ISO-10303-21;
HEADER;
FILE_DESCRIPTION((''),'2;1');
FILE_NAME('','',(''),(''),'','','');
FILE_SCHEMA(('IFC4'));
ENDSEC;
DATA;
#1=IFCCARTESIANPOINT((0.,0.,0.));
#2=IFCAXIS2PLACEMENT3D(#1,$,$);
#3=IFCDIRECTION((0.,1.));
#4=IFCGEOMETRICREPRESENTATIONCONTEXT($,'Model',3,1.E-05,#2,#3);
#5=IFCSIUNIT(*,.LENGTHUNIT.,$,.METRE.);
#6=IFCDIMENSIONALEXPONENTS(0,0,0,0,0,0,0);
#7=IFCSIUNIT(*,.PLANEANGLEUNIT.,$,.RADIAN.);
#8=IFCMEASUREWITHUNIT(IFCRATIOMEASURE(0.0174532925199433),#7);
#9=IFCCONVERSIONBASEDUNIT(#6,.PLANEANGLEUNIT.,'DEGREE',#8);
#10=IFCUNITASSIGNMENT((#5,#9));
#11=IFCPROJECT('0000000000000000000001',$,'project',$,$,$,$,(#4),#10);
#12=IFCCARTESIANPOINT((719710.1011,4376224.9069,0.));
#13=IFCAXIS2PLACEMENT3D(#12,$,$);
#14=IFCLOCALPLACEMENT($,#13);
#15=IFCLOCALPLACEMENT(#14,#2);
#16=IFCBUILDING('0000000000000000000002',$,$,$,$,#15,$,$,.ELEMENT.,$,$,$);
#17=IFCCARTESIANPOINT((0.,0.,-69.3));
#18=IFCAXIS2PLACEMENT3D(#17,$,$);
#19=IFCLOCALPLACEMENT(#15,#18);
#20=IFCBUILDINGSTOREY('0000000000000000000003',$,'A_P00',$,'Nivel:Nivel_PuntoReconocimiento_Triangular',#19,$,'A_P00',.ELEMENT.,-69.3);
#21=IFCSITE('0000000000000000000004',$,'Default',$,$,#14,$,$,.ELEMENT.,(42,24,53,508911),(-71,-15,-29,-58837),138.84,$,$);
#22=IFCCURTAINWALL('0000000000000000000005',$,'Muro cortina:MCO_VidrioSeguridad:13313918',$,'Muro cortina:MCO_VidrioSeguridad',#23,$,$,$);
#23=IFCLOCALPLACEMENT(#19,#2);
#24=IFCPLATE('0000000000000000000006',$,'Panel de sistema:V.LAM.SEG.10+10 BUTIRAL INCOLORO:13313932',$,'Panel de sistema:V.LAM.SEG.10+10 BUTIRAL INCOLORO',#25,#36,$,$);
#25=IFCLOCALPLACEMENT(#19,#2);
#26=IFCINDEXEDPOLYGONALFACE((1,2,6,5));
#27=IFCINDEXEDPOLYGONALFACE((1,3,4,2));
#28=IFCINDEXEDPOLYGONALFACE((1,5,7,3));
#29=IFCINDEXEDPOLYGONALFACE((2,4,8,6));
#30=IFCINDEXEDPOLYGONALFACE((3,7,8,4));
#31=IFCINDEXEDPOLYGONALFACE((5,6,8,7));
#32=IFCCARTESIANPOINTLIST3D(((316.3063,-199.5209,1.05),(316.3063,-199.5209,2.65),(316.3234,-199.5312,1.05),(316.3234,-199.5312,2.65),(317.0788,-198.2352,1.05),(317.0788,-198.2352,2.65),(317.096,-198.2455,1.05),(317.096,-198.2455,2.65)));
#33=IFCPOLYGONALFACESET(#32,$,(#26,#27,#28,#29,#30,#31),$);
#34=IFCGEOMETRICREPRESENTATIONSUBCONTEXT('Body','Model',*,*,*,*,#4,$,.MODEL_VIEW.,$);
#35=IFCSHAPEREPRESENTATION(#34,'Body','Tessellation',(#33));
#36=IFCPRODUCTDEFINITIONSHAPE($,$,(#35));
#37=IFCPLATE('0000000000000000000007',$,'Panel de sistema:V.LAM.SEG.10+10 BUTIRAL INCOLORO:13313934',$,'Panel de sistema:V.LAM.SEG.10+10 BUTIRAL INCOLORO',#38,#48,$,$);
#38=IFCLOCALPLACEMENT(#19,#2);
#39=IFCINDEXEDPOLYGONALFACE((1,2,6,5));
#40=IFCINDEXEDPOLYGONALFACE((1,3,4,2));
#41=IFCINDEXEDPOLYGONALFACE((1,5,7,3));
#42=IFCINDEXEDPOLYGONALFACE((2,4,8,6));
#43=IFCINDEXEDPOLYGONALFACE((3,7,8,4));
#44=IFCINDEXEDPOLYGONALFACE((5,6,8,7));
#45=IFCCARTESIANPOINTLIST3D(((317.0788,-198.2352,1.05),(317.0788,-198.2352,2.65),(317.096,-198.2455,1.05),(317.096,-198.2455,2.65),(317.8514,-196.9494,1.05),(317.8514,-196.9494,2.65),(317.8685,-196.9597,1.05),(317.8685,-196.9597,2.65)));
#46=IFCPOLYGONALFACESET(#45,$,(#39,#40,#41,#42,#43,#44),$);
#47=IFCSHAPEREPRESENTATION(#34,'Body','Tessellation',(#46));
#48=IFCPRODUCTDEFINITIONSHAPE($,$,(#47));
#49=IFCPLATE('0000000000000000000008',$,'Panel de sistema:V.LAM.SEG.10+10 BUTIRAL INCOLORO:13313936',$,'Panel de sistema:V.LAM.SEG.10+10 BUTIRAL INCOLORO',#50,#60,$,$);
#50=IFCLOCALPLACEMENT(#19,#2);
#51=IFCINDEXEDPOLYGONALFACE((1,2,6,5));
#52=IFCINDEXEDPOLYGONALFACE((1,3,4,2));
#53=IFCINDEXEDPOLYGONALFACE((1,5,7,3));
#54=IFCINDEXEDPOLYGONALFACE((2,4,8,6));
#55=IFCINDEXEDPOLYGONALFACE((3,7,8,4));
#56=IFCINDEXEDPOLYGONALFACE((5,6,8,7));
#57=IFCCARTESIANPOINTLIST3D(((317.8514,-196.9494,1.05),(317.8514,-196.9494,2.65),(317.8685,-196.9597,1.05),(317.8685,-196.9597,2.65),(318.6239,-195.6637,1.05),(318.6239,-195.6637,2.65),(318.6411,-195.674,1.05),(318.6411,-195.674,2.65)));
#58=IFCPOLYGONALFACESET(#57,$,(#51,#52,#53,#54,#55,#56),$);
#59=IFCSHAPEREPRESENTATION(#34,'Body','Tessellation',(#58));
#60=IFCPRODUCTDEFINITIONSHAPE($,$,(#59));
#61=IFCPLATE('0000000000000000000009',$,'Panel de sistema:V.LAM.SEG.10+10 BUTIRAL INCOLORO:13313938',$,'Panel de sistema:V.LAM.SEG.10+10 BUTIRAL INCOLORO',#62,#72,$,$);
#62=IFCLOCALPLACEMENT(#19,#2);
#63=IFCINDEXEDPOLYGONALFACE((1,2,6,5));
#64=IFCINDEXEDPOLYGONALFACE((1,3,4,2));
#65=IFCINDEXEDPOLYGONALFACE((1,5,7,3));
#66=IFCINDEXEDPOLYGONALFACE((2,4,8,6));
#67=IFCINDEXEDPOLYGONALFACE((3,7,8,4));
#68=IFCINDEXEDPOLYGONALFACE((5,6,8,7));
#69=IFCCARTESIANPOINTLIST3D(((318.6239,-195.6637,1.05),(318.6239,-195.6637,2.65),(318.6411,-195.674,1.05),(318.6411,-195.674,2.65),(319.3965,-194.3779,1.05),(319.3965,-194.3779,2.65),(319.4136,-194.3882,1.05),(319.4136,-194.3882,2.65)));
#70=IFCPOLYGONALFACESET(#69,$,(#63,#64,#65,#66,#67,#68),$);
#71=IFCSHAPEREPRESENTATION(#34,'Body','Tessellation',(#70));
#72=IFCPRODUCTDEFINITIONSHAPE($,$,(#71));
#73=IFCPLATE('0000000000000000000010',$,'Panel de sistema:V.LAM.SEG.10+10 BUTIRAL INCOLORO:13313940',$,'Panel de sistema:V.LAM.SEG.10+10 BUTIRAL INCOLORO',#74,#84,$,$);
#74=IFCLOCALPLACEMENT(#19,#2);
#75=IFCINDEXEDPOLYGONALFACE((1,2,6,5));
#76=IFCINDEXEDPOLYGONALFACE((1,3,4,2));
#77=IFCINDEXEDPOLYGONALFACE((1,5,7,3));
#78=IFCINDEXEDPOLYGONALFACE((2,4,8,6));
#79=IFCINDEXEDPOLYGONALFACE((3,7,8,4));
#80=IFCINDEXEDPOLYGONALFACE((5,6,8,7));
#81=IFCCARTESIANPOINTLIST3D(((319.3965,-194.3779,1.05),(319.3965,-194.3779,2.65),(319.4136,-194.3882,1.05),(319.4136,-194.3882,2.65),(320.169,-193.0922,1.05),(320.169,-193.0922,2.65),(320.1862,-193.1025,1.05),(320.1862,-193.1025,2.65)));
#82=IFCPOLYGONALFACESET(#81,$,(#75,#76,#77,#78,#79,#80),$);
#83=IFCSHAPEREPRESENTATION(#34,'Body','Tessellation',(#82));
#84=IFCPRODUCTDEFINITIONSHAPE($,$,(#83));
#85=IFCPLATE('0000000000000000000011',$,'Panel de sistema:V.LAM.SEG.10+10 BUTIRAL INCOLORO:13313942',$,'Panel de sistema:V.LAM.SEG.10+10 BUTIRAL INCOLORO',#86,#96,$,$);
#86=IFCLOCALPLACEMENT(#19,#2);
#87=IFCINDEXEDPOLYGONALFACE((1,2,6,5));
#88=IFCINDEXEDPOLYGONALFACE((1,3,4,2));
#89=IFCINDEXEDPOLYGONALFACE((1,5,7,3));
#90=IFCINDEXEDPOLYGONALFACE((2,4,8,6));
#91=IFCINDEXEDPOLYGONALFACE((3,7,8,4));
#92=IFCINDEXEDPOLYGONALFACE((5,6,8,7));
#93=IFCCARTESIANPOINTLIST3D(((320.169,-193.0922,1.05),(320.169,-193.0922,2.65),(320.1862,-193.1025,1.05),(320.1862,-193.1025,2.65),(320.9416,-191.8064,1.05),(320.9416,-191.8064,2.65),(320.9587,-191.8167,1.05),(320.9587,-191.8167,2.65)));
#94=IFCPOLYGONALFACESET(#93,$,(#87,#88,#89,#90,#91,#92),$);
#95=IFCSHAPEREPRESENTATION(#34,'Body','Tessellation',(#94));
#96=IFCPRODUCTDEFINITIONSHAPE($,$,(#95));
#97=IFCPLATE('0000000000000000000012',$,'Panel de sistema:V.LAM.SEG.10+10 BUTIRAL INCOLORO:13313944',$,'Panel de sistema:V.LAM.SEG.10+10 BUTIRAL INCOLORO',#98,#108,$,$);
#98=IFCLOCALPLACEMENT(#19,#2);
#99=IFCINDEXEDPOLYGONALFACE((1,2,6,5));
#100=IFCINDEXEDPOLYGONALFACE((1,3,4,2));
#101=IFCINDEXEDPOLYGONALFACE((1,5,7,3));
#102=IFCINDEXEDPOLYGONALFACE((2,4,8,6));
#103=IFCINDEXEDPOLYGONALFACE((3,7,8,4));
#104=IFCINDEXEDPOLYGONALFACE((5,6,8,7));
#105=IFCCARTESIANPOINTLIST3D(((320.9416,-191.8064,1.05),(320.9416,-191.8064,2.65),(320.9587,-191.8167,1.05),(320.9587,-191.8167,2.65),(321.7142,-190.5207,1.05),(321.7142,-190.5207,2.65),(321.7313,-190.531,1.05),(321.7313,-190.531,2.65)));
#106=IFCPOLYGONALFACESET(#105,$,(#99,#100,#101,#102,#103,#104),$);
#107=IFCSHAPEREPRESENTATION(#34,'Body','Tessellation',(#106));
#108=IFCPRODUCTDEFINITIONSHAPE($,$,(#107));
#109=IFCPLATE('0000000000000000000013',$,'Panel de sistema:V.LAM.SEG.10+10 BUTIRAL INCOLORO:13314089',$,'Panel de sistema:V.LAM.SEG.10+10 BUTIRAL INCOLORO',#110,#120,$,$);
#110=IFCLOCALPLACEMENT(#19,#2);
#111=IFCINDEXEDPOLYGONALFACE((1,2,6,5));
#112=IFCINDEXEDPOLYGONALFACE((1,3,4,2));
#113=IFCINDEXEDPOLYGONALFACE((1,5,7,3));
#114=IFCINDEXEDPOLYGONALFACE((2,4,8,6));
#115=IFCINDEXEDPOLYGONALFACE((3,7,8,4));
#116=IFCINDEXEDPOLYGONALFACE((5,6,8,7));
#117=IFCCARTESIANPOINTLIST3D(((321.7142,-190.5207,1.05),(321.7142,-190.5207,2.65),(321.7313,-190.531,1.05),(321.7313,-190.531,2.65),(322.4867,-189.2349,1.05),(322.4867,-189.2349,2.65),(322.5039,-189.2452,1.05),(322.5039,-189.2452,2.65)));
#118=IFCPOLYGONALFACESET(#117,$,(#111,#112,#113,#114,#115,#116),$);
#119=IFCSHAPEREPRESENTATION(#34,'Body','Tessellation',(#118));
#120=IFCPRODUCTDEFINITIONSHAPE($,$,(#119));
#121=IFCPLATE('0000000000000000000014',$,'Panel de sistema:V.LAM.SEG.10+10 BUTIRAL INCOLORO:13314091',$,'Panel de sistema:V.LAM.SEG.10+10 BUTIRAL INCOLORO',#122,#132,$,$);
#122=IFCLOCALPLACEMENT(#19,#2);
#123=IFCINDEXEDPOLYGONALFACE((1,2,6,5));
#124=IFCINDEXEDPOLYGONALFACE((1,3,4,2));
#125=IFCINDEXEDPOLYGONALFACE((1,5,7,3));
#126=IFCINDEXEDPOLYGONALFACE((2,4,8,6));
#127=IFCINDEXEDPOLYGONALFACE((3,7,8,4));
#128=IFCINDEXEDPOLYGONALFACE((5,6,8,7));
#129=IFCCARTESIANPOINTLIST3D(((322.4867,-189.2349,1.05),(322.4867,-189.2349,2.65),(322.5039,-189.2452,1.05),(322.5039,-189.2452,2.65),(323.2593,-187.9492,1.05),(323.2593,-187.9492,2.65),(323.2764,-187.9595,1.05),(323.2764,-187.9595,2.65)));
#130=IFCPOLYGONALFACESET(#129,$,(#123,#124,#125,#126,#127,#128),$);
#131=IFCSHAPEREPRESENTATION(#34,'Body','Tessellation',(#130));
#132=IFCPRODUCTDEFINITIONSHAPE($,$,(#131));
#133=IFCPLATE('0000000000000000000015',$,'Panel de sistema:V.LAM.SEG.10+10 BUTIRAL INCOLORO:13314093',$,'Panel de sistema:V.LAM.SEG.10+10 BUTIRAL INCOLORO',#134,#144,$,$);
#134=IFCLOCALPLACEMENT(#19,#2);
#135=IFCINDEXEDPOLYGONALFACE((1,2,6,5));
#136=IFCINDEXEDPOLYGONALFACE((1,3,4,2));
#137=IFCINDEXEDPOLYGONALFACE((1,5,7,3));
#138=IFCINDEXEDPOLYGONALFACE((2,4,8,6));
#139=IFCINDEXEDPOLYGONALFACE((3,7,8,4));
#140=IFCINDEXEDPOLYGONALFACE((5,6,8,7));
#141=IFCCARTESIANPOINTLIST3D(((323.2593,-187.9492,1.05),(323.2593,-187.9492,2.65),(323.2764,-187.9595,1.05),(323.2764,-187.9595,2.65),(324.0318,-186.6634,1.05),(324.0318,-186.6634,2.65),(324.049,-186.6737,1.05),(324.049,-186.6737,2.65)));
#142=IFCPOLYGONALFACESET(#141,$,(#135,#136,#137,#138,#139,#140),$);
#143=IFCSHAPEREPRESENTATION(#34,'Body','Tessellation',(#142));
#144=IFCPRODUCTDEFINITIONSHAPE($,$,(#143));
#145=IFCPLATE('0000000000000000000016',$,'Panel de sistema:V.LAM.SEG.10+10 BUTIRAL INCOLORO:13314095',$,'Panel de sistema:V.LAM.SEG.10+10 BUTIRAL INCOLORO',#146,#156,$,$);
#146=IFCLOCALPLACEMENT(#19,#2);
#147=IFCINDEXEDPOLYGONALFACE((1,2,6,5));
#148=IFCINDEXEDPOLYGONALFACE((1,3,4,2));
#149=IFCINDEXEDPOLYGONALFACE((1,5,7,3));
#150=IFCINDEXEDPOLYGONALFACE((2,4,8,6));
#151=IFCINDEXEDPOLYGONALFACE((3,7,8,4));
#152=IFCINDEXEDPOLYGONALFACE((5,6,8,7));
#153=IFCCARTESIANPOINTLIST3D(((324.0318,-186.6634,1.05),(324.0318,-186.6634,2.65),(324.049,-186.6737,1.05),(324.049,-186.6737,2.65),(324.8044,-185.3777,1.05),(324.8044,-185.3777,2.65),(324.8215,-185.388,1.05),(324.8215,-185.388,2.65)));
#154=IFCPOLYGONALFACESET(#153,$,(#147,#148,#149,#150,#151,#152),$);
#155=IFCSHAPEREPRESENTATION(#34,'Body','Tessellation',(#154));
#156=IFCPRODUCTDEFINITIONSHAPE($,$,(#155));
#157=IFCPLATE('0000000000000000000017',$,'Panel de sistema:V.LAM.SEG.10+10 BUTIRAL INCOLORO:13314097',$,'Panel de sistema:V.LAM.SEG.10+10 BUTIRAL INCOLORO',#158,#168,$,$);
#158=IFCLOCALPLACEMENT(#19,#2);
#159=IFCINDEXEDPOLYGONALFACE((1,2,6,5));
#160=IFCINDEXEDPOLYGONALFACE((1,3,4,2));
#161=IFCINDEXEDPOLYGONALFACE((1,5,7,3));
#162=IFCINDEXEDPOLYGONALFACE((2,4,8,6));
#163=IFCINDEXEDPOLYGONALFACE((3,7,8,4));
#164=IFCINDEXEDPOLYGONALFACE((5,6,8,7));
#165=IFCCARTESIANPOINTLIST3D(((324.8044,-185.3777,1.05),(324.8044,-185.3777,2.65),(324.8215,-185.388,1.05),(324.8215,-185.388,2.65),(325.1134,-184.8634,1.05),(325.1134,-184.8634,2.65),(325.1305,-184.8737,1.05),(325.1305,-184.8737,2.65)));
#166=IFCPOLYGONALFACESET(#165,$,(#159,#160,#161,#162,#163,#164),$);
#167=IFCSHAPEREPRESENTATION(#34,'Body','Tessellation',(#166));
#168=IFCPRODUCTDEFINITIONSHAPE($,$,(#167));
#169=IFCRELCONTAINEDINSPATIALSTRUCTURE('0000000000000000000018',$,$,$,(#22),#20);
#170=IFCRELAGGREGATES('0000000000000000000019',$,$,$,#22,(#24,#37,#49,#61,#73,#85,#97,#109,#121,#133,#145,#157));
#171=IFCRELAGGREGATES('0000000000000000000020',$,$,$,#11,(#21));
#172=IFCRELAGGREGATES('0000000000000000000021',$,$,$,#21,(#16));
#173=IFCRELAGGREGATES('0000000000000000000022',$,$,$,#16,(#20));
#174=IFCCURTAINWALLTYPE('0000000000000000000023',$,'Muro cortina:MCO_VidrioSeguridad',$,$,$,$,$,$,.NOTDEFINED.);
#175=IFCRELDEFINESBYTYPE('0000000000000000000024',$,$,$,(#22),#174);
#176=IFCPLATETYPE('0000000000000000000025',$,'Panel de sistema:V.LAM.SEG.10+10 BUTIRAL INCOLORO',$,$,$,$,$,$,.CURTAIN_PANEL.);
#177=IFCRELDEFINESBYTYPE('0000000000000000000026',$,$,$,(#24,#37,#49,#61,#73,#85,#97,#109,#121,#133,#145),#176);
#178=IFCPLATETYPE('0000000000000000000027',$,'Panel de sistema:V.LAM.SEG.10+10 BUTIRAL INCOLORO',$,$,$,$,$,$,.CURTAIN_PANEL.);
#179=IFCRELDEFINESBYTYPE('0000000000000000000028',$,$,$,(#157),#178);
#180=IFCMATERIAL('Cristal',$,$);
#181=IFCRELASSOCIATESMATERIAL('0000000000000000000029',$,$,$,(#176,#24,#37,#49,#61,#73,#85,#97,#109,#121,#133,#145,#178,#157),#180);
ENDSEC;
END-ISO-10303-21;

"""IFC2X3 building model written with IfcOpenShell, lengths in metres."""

from ifc_helpers import new_model, entity, si_unit, converted_unit, direction, frame, frame_2d, origin, origin_2d_with_axis, place, context, subcontext, project, spatial, rectangle, extrude, source, transform, mapped, material, type_object, type_shapes, element, aggregate, save


model = new_model("IFC2X3")

# Units and contexts
model_context = context("Model", 3, precision=1e-05, world=origin(), true_north=direction((0.0, 1.0)))
body_context = subcontext(model_context, "Body", "Model", "MODEL_VIEW")
ifc_project = project(units=[si_unit("LENGTHUNIT", "METRE"), converted_unit("PLANEANGLEUNIT", "DEGREE", entity("IfcRatioMeasure", 0.0174532925199433), si_unit("PLANEANGLEUNIT", "RADIAN"), dimensions=[0, 0, 0, 0, 0, 0, 0])], contexts=[model_context])

# Site, building, storey
site_placement = place(None, frame((719710.1011, 4376224.9069, 0.0)))
site = spatial("IfcSite", under=ifc_project, at=site_placement, Name="Default", CompositionType="ELEMENT", RefLatitude=(42, 24, 53, 508911), RefLongitude=(-71, -15, -29, -58837), RefElevation=138.84)
building_placement = place(site_placement, origin())
building = spatial("IfcBuilding", under=site, at=building_placement, CompositionType="ELEMENT")
storey_placement = place(building_placement, frame((0.0, 0.0, -69.3)))
storey = spatial("IfcBuildingStorey", under=building, at=storey_placement, Name="A_P00", ObjectType="Nivel:Nivel_PuntoReconocimiento_Triangular", LongName="A_P00", CompositionType="ELEMENT", Elevation=-69.3)

# Shared definitions
curtain_wall_type = type_object("IfcCurtainWallType", Name="Muro cortina:MCO_VidrioSeguridad", PredefinedType="NOTDEFINED")
ifc_material_1 = material(Name="Cristal")

# Curtain wall, plates
curtain_wall_1_placement = place(storey_placement, frame((0.0, 0.0, 69.3)))
curtain_wall_1 = element("IfcCurtainWall", 1, at=curtain_wall_1_placement, inside=storey, type_object=curtain_wall_type, Name="Muro cortina:MCO_VidrioSeguridad:13313918", ObjectType="Muro cortina:MCO_VidrioSeguridad")
plate_type_1 = type_object("IfcPlateType", Name="Panel de sistema:V.LAM.SEG.10+10 BUTIRAL INCOLORO", PredefinedType="CURTAIN_PANEL", material=ifc_material_1)
shared_shape_1 = source(origin(), body_context, "Body", "SweptSolid", [
    extrude(rectangle(XDim=0.02, YDim=1.5, at=frame_2d((0.0, 0.0), x_axis=(1.0, 0.0))), frame((0.0, 0.0, 0.0), z_axis=(0.0, 0.0, 1.0), x_axis=(0.0, 1.0, 0.0)), (0.0, 0.0, 1.0), 1.6),
])
type_shapes(plate_type_1, [shared_shape_1])
plate_1_placement = place(curtain_wall_1_placement, frame((316.7011, -198.8832, -68.25), z_axis=(0.0, 0.0, 1.0), x_axis=(0.515038, 0.857167, 0.0)))
plate_1 = element("IfcPlate", 2, at=plate_1_placement, type_object=plate_type_1, material=ifc_material_1, Name="Panel de sistema:V.LAM.SEG.10+10 BUTIRAL INCOLORO:13313932", ObjectType="Panel de sistema:V.LAM.SEG.10+10 BUTIRAL INCOLORO", context=body_context, shape_type="MappedRepresentation", body=[
    mapped(shared_shape_1, transform((0.0, 0.0, 0.0), scale=1.0)),
])
plate_2_placement = place(curtain_wall_1_placement, frame((317.4737, -197.5974, -68.25), z_axis=(0.0, 0.0, 1.0), x_axis=(0.515038, 0.857167, 0.0)))
plate_2 = element("IfcPlate", 3, at=plate_2_placement, type_object=plate_type_1, material=ifc_material_1, Name="Panel de sistema:V.LAM.SEG.10+10 BUTIRAL INCOLORO:13313934", ObjectType="Panel de sistema:V.LAM.SEG.10+10 BUTIRAL INCOLORO", context=body_context, shape_type="MappedRepresentation", body=[
    mapped(shared_shape_1, transform((0.0, 0.0, 0.0), scale=1.0)),
])
plate_3_placement = place(curtain_wall_1_placement, frame((318.2462, -196.3117, -68.25), z_axis=(0.0, 0.0, 1.0), x_axis=(0.515038, 0.857167, 0.0)))
plate_3 = element("IfcPlate", 4, at=plate_3_placement, type_object=plate_type_1, material=ifc_material_1, Name="Panel de sistema:V.LAM.SEG.10+10 BUTIRAL INCOLORO:13313936", ObjectType="Panel de sistema:V.LAM.SEG.10+10 BUTIRAL INCOLORO", context=body_context, shape_type="MappedRepresentation", body=[
    mapped(shared_shape_1, transform((0.0, 0.0, 0.0), scale=1.0)),
])
plate_4_placement = place(curtain_wall_1_placement, frame((319.0188, -195.0259, -68.25), z_axis=(0.0, 0.0, 1.0), x_axis=(0.515038, 0.857167, 0.0)))
plate_4 = element("IfcPlate", 5, at=plate_4_placement, type_object=plate_type_1, material=ifc_material_1, Name="Panel de sistema:V.LAM.SEG.10+10 BUTIRAL INCOLORO:13313938", ObjectType="Panel de sistema:V.LAM.SEG.10+10 BUTIRAL INCOLORO", context=body_context, shape_type="MappedRepresentation", body=[
    mapped(shared_shape_1, transform((0.0, 0.0, 0.0), scale=1.0)),
])
plate_5_placement = place(curtain_wall_1_placement, frame((319.7913, -193.7402, -68.25), z_axis=(0.0, 0.0, 1.0), x_axis=(0.515038, 0.857167, 0.0)))
plate_5 = element("IfcPlate", 6, at=plate_5_placement, type_object=plate_type_1, material=ifc_material_1, Name="Panel de sistema:V.LAM.SEG.10+10 BUTIRAL INCOLORO:13313940", ObjectType="Panel de sistema:V.LAM.SEG.10+10 BUTIRAL INCOLORO", context=body_context, shape_type="MappedRepresentation", body=[
    mapped(shared_shape_1, transform((0.0, 0.0, 0.0), scale=1.0)),
])
plate_6_placement = place(curtain_wall_1_placement, frame((320.5639, -192.4544, -68.25), z_axis=(0.0, 0.0, 1.0), x_axis=(0.515038, 0.857167, 0.0)))
plate_6 = element("IfcPlate", 7, at=plate_6_placement, type_object=plate_type_1, material=ifc_material_1, Name="Panel de sistema:V.LAM.SEG.10+10 BUTIRAL INCOLORO:13313942", ObjectType="Panel de sistema:V.LAM.SEG.10+10 BUTIRAL INCOLORO", context=body_context, shape_type="MappedRepresentation", body=[
    mapped(shared_shape_1, transform((0.0, 0.0, 0.0), scale=1.0)),
])
plate_7_placement = place(curtain_wall_1_placement, frame((321.3364, -191.1687, -68.25), z_axis=(0.0, 0.0, 1.0), x_axis=(0.515038, 0.857167, 0.0)))
plate_7 = element("IfcPlate", 8, at=plate_7_placement, type_object=plate_type_1, material=ifc_material_1, Name="Panel de sistema:V.LAM.SEG.10+10 BUTIRAL INCOLORO:13313944", ObjectType="Panel de sistema:V.LAM.SEG.10+10 BUTIRAL INCOLORO", context=body_context, shape_type="MappedRepresentation", body=[
    mapped(shared_shape_1, transform((0.0, 0.0, 0.0), scale=1.0)),
])
plate_8_placement = place(curtain_wall_1_placement, frame((322.109, -189.8829, -68.25), z_axis=(0.0, 0.0, 1.0), x_axis=(0.515038, 0.857167, 0.0)))
plate_8 = element("IfcPlate", 9, at=plate_8_placement, type_object=plate_type_1, material=ifc_material_1, Name="Panel de sistema:V.LAM.SEG.10+10 BUTIRAL INCOLORO:13314089", ObjectType="Panel de sistema:V.LAM.SEG.10+10 BUTIRAL INCOLORO", context=body_context, shape_type="MappedRepresentation", body=[
    mapped(shared_shape_1, transform((0.0, 0.0, 0.0), scale=1.0)),
])
plate_9_placement = place(curtain_wall_1_placement, frame((322.8816, -188.5972, -68.25), z_axis=(0.0, 0.0, 1.0), x_axis=(0.515038, 0.857167, 0.0)))
plate_9 = element("IfcPlate", 10, at=plate_9_placement, type_object=plate_type_1, material=ifc_material_1, Name="Panel de sistema:V.LAM.SEG.10+10 BUTIRAL INCOLORO:13314091", ObjectType="Panel de sistema:V.LAM.SEG.10+10 BUTIRAL INCOLORO", context=body_context, shape_type="MappedRepresentation", body=[
    mapped(shared_shape_1, transform((0.0, 0.0, 0.0), scale=1.0)),
])
plate_10_placement = place(curtain_wall_1_placement, frame((323.6541, -187.3114, -68.25), z_axis=(0.0, 0.0, 1.0), x_axis=(0.515038, 0.857167, 0.0)))
plate_10 = element("IfcPlate", 11, at=plate_10_placement, type_object=plate_type_1, material=ifc_material_1, Name="Panel de sistema:V.LAM.SEG.10+10 BUTIRAL INCOLORO:13314093", ObjectType="Panel de sistema:V.LAM.SEG.10+10 BUTIRAL INCOLORO", context=body_context, shape_type="MappedRepresentation", body=[
    mapped(shared_shape_1, transform((0.0, 0.0, 0.0), scale=1.0)),
])
plate_11_placement = place(curtain_wall_1_placement, frame((324.4267, -186.0257, -68.25), z_axis=(0.0, 0.0, 1.0), x_axis=(0.515038, 0.857167, 0.0)))
plate_11 = element("IfcPlate", 12, at=plate_11_placement, type_object=plate_type_1, material=ifc_material_1, Name="Panel de sistema:V.LAM.SEG.10+10 BUTIRAL INCOLORO:13314095", ObjectType="Panel de sistema:V.LAM.SEG.10+10 BUTIRAL INCOLORO", context=body_context, shape_type="MappedRepresentation", body=[
    mapped(shared_shape_1, transform((0.0, 0.0, 0.0), scale=1.0)),
])
plate_type_2 = type_object("IfcPlateType", Name="Panel de sistema:V.LAM.SEG.10+10 BUTIRAL INCOLORO", PredefinedType="CURTAIN_PANEL", material=ifc_material_1)
shared_shape_2 = source(origin(), body_context, "Body", "SweptSolid", [
    extrude(rectangle(XDim=0.02, YDim=0.6, at=origin_2d_with_axis()), frame((0.0, 0.0, 0.0), z_axis=(0.0, 0.0, 1.0), x_axis=(0.0, 1.0, 0.0)), (0.0, 0.0, 1.0), 1.6),
])
type_shapes(plate_type_2, [shared_shape_2])
plate_12_placement = place(curtain_wall_1_placement, frame((324.9675, -185.1257, -68.25), z_axis=(0.0, 0.0, 1.0), x_axis=(0.515038, 0.857167, 0.0)))
plate_12 = element("IfcPlate", 13, at=plate_12_placement, type_object=plate_type_2, material=ifc_material_1, Name="Panel de sistema:V.LAM.SEG.10+10 BUTIRAL INCOLORO:13314097", ObjectType="Panel de sistema:V.LAM.SEG.10+10 BUTIRAL INCOLORO", context=body_context, shape_type="MappedRepresentation", body=[
    mapped(shared_shape_2, transform((0.0, 0.0, 0.0), scale=1.0)),
])
aggregate(curtain_wall_1, [plate_1, plate_2, plate_3, plate_4, plate_5, plate_6, plate_7, plate_8, plate_9, plate_10, plate_11, plate_12])

save(model, "model.ifc")
